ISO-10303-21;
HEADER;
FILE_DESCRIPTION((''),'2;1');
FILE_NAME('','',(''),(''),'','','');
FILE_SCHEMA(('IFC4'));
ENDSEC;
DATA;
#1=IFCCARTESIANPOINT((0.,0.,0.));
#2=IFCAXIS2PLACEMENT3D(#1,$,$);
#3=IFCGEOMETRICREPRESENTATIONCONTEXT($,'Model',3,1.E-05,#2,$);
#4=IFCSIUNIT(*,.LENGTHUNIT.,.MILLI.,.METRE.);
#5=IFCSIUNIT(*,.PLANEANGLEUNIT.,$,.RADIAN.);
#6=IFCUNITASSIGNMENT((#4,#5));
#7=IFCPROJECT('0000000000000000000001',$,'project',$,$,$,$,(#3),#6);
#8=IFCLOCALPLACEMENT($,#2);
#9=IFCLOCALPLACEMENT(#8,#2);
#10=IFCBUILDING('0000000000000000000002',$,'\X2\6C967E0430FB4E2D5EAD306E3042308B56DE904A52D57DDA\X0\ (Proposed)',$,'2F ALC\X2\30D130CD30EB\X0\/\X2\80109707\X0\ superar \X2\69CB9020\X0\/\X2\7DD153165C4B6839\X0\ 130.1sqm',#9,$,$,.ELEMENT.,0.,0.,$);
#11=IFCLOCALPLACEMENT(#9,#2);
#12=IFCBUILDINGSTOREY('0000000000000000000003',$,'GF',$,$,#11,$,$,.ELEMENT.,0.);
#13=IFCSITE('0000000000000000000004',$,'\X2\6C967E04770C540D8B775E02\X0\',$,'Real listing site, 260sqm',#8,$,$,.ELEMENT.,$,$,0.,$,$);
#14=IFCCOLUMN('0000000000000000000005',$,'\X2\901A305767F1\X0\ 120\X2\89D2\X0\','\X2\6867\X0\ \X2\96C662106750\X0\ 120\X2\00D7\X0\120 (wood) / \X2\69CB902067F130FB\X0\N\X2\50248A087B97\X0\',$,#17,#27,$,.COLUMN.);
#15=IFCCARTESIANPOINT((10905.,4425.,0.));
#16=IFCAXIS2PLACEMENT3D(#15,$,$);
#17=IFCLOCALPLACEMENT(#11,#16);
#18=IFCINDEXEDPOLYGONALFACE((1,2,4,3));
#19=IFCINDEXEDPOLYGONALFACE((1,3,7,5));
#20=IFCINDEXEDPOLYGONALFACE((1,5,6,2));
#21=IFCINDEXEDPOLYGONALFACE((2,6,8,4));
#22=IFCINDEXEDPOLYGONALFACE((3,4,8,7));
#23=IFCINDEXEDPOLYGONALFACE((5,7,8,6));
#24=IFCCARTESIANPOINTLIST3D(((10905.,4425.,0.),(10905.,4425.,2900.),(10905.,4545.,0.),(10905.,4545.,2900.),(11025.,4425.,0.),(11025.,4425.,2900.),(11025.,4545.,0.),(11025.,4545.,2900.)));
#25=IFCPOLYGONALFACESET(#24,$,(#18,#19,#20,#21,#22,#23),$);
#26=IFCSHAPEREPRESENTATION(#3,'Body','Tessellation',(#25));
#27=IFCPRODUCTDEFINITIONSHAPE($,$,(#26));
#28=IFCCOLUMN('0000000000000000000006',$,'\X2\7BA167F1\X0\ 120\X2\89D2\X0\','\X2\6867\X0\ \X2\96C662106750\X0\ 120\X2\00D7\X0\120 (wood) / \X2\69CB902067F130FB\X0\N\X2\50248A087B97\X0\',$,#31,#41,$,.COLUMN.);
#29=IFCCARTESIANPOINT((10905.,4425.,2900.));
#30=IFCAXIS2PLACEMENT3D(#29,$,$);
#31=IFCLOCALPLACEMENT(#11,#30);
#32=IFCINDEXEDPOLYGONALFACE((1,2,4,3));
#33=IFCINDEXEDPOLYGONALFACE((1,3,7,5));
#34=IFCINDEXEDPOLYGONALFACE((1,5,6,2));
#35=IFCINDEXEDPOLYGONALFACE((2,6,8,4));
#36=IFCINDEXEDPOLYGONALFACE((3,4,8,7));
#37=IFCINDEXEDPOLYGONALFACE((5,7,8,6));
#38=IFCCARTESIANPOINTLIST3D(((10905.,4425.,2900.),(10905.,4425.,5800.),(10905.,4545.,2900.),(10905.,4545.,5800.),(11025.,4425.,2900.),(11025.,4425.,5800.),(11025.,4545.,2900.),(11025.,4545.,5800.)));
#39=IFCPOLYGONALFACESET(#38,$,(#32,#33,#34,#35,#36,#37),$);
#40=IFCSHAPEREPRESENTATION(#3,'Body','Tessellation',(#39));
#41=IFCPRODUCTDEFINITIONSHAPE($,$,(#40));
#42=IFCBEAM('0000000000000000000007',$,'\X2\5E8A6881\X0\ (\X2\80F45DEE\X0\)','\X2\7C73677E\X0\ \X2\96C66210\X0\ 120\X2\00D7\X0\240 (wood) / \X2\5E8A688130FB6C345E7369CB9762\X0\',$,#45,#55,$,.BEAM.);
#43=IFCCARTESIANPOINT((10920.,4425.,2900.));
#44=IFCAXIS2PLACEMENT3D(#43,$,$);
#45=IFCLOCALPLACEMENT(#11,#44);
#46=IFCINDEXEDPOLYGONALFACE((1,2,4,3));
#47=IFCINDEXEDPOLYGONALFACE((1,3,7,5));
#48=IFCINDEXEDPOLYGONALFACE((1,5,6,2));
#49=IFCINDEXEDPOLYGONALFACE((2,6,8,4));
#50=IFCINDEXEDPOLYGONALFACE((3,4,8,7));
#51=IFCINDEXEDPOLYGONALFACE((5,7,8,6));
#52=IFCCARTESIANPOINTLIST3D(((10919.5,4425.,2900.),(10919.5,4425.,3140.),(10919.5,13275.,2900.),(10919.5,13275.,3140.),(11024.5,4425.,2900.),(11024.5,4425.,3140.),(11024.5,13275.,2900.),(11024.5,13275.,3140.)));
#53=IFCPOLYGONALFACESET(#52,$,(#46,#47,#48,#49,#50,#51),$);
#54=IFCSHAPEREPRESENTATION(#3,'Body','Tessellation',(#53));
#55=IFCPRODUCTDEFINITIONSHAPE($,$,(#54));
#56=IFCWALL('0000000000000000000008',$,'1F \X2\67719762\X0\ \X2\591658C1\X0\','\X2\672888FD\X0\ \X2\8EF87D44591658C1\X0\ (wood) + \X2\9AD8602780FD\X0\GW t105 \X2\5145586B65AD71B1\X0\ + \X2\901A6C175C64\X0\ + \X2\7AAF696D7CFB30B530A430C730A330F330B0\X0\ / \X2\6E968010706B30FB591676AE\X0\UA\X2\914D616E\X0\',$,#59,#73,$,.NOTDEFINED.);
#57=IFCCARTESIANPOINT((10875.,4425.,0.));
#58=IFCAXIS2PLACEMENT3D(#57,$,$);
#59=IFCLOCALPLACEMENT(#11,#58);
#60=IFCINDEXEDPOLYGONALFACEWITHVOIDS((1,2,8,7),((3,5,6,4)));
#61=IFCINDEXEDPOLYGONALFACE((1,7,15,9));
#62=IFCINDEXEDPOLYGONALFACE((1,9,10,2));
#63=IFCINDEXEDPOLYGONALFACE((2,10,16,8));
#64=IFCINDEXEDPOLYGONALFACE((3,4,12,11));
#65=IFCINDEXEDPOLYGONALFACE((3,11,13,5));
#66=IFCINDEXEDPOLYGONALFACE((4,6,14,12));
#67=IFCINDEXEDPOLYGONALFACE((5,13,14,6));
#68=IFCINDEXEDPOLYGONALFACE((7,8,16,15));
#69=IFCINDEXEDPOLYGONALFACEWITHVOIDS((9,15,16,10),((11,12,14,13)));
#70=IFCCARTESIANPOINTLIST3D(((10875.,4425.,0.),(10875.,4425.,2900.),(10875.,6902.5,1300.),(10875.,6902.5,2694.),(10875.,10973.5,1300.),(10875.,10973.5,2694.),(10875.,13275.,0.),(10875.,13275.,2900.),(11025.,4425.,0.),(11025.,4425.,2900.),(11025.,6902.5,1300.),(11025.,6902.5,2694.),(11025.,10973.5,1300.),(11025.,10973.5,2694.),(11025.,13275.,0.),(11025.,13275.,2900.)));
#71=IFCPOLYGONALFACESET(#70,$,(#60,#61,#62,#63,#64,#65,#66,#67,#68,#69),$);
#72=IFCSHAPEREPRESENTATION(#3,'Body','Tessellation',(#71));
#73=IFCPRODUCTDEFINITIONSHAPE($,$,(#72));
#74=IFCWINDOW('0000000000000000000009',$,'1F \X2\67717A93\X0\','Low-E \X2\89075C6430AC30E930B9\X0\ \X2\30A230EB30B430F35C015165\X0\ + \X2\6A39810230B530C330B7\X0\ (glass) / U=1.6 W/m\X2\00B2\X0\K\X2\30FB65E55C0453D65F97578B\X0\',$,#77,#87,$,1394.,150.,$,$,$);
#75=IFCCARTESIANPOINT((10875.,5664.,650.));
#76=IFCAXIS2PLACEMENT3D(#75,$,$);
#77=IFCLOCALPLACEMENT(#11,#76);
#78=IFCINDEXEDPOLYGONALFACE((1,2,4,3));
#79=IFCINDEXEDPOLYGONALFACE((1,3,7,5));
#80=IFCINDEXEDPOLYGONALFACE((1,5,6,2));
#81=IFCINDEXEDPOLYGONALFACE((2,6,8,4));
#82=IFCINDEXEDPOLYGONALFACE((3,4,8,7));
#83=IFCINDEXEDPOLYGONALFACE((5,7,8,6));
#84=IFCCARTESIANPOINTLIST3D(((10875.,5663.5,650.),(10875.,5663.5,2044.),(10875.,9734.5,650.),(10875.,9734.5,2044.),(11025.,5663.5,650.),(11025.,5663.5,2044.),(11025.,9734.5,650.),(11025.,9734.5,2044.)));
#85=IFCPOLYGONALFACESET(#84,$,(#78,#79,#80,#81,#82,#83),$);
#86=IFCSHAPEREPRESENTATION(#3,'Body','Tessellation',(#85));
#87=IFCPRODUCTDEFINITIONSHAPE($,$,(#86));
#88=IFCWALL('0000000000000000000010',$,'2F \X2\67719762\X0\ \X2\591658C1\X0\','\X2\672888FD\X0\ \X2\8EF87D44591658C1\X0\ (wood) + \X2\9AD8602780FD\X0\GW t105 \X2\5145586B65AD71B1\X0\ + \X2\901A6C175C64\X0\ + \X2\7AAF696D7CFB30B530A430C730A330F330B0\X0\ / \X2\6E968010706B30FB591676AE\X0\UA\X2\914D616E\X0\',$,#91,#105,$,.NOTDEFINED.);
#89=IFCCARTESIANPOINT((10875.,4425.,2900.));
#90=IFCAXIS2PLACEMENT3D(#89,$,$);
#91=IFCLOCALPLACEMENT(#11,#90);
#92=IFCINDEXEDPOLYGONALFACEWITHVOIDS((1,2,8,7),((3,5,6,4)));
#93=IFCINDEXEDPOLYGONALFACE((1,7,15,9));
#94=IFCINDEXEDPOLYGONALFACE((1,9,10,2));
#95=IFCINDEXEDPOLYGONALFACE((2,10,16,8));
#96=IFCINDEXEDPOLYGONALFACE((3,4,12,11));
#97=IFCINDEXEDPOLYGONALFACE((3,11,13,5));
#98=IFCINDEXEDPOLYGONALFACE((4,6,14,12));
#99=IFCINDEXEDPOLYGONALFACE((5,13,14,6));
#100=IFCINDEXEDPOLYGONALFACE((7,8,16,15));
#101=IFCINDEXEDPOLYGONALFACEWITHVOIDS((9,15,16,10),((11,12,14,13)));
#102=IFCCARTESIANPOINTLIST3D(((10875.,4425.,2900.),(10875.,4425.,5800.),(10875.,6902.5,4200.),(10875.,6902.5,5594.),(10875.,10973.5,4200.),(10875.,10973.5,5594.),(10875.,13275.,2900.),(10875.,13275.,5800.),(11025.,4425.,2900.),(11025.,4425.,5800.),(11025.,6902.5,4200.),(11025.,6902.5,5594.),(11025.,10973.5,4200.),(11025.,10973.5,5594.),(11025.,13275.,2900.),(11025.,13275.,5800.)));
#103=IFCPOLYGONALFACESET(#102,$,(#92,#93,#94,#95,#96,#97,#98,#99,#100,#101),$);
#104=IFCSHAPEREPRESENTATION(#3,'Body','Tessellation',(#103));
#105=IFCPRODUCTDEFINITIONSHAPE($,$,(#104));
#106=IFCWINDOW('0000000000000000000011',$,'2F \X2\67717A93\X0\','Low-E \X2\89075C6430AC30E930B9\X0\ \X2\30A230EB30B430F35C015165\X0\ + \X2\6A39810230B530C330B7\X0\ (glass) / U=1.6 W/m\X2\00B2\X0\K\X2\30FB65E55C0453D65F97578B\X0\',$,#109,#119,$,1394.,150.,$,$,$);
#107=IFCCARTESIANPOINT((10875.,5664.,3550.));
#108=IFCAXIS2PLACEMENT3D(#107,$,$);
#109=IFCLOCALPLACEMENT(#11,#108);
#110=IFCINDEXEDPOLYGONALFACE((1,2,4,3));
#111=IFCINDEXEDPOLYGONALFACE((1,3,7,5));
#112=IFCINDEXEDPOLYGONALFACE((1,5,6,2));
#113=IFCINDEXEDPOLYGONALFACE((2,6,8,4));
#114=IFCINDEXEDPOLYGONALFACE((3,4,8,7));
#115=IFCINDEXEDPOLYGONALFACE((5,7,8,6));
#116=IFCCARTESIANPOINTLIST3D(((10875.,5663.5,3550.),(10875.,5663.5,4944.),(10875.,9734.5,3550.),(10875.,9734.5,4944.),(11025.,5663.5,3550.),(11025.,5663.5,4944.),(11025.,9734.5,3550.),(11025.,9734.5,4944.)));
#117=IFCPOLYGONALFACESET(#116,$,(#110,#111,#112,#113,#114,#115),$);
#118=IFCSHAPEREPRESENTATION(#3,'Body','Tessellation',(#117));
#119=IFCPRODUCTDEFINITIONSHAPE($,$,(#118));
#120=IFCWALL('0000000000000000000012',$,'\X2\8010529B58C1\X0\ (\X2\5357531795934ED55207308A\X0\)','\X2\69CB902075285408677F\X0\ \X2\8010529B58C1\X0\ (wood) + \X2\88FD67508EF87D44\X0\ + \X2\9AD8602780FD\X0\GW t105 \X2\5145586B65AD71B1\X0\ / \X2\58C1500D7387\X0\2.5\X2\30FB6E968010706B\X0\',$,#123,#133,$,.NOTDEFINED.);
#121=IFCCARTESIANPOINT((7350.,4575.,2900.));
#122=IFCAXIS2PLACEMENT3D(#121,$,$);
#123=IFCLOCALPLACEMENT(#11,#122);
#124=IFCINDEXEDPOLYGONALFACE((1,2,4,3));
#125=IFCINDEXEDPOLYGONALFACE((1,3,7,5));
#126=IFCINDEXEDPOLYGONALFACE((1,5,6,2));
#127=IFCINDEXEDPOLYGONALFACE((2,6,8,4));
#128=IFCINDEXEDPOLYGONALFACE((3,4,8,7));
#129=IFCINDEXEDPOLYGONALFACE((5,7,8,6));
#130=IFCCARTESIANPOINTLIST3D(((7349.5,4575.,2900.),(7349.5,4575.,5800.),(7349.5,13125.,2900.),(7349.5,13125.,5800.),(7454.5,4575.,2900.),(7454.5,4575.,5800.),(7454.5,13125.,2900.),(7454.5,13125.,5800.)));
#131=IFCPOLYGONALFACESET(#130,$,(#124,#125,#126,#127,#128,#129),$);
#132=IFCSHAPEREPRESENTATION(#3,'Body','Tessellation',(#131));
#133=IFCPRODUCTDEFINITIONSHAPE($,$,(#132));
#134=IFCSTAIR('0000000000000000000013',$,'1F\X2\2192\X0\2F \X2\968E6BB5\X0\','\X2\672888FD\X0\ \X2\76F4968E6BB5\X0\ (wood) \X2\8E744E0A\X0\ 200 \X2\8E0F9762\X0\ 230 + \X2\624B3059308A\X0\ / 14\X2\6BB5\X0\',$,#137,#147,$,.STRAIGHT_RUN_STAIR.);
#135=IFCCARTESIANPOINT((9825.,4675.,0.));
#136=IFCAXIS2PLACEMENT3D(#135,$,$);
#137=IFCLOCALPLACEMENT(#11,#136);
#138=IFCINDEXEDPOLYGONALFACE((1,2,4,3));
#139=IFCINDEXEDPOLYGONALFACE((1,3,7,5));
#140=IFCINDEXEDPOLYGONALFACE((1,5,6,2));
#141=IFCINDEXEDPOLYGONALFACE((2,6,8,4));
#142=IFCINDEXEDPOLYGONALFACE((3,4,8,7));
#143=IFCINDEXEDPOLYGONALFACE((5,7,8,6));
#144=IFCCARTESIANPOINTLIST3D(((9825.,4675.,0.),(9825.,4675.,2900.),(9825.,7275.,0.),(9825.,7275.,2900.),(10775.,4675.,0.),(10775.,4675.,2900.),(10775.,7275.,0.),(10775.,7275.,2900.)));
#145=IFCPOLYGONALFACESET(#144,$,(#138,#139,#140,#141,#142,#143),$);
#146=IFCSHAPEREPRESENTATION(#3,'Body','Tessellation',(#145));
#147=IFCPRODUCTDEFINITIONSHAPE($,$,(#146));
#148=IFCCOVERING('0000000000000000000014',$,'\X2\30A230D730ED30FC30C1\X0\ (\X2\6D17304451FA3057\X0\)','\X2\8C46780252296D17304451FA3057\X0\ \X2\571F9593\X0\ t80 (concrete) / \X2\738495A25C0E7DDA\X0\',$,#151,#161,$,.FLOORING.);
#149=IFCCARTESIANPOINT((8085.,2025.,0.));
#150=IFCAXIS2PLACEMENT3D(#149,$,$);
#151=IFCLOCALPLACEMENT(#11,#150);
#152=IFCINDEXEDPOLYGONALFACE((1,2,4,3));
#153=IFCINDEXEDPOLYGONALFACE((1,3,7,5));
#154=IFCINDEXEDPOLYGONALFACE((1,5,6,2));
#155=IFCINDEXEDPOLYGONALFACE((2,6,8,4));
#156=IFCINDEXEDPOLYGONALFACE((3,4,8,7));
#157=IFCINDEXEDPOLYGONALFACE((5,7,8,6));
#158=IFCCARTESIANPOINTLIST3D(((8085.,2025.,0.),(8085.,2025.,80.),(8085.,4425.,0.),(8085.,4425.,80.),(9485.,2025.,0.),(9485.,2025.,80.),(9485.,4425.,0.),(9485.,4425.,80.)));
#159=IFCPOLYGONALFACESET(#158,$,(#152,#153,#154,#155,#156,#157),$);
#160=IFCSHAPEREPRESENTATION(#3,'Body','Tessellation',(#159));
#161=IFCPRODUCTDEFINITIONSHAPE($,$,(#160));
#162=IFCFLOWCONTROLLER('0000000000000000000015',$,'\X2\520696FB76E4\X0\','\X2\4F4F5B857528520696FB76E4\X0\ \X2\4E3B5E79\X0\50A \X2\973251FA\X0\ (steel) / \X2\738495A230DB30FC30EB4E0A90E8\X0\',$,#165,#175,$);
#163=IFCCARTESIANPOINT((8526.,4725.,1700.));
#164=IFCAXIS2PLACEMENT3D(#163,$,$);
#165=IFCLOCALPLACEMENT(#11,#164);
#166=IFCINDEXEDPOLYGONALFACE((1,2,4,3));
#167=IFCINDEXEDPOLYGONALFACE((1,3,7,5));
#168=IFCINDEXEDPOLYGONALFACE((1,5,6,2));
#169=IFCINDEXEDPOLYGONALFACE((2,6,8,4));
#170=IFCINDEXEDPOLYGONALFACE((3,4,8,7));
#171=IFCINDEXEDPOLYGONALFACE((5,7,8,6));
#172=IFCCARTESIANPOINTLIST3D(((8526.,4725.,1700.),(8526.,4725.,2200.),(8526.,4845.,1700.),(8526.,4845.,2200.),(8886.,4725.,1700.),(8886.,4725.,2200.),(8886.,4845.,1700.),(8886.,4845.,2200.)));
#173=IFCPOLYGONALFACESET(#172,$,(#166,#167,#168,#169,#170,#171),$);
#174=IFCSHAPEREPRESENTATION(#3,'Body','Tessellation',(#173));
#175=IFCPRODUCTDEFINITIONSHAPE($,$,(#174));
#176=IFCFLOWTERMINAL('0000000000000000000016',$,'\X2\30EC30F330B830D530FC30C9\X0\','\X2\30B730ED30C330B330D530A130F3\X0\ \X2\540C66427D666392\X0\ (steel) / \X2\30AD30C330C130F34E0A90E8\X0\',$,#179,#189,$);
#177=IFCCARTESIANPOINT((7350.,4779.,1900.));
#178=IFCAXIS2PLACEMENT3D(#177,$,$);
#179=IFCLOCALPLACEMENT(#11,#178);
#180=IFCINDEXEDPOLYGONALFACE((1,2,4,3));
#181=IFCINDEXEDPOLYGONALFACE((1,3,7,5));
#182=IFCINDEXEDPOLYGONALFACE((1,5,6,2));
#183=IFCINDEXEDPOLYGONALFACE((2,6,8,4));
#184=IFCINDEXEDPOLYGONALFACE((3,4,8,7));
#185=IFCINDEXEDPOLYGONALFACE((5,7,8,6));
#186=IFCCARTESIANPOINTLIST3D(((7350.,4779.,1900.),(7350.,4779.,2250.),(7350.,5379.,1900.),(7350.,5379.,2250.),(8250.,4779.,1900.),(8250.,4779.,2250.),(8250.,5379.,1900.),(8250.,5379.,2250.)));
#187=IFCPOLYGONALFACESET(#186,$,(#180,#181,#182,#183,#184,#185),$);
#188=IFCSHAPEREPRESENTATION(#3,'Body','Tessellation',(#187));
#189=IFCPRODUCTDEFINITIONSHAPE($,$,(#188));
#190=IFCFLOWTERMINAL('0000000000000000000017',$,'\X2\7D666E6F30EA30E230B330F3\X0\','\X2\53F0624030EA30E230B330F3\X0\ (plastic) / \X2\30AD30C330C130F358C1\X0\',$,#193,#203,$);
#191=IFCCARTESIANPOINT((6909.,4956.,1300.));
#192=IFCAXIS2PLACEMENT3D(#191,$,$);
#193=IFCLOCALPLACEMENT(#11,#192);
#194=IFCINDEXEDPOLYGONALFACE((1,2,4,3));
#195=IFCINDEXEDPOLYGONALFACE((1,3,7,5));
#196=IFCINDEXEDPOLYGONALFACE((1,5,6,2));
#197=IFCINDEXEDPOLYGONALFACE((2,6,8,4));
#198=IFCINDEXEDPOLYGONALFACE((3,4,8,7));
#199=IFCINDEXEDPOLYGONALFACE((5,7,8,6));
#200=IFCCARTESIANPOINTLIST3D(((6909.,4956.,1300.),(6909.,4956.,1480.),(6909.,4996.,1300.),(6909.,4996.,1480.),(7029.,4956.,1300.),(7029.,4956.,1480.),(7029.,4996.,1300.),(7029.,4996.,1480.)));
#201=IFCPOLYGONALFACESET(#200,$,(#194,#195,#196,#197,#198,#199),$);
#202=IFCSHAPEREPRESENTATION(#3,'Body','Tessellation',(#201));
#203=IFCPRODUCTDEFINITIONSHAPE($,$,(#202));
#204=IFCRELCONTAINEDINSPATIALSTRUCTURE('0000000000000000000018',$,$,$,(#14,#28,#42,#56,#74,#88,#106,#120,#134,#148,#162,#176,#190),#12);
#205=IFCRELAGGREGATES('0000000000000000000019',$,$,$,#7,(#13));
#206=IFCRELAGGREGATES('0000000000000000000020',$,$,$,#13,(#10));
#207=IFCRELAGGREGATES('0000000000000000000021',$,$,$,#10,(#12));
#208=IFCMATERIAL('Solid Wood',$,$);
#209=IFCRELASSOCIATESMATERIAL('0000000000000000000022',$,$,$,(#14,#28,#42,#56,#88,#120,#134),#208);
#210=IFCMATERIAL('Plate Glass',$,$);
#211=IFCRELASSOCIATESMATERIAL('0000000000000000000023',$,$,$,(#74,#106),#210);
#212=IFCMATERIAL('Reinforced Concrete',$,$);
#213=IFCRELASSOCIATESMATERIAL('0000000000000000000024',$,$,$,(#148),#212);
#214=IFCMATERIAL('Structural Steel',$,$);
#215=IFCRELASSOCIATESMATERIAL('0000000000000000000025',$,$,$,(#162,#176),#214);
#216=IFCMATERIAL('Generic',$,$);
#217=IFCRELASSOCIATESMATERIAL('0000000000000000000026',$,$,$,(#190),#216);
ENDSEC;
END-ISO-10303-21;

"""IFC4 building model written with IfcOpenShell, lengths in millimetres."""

from ifc_helpers import new_model, si_unit, frame, frame_2d, origin, place, context, project, spatial, rectangle, extrude, material, element, fill, save


model = new_model("IFC4")

# Units and contexts
model_context = context("Model", 3, precision=1e-05, world=origin())
ifc_project = project(units=[si_unit("LENGTHUNIT", "METRE", prefix="MILLI"), si_unit("PLANEANGLEUNIT", "RADIAN")], contexts=[model_context])

# Site, building, storey
site_placement = place(None, origin())
site = spatial("IfcSite", under=ifc_project, at=site_placement, Name="沖縄県名護市", ObjectType="Real listing site, 260sqm", CompositionType="ELEMENT", RefElevation=0.0)
building_placement = place(site_placement, origin())
building = spatial("IfcBuilding", under=site, at=building_placement, Name="沖縄・中庭のある回遊動線 (Proposed)", ObjectType="2F ALCパネル/耐震 superar 構造/緑化屋根 130.1sqm", CompositionType="ELEMENT", ElevationOfRefHeight=0.0, ElevationOfTerrain=0.0)
storey_placement = place(building_placement, origin())
storey = spatial("IfcBuildingStorey", under=building, at=storey_placement, Name="GF", CompositionType="ELEMENT", Elevation=0.0)

# Columns
ifc_material_1 = material(Name="Solid Wood")
column_1_placement = place(storey_placement, frame((10905.0, 4425.0, 0.0)))
element("IfcColumn", 1, at=column_1_placement, inside=storey, material=ifc_material_1, Name="通し柱 120角", Description="桧 集成材 120×120 (wood) / 構造柱・N値計算", PredefinedType="COLUMN", context=model_context, shape_type="SweptSolid", body=[
    extrude(rectangle(XDim=120.0, YDim=120.0, at=frame_2d((60.0, 60.0))), frame((10905.0, 4425.0, 0.0)), (0.0, 0.0, 1.0), 2900.0),
])
column_2_placement = place(storey_placement, frame((10905.0, 4425.0, 2900.0)))
element("IfcColumn", 2, at=column_2_placement, inside=storey, material=ifc_material_1, Name="管柱 120角", Description="桧 集成材 120×120 (wood) / 構造柱・N値計算", PredefinedType="COLUMN", context=model_context, shape_type="SweptSolid", body=[
    extrude(rectangle(XDim=120.0, YDim=120.0, at=frame_2d((60.0, 60.0))), frame((10905.0, 4425.0, 2900.0)), (0.0, 0.0, 1.0), 2900.0),
])

# Beam
beam_1_placement = place(storey_placement, frame((10920.0, 4425.0, 2900.0)))
element("IfcBeam", 3, at=beam_1_placement, inside=storey, material=ifc_material_1, Name="床梁 (胴差)", Description="米松 集成 120×240 (wood) / 床梁・水平構面", PredefinedType="BEAM", context=model_context, shape_type="SweptSolid", body=[
    extrude(rectangle(XDim=105.0, YDim=8850.0, at=frame_2d((52.0, 4425.0))), frame((10920.0, 4425.0, 2900.0)), (0.0, 0.0, 1.0), 240.0),
])

# Wall, opening, window
wall_1_placement = place(storey_placement, frame((10875.0, 4425.0, 0.0)))
wall_1 = element("IfcWall", 4, at=wall_1_placement, inside=storey, material=ifc_material_1, Name="1F 東面 外壁", Description="木製 軸組外壁 (wood) + 高性能GW t105 充填断熱 + 通気層 + 窯業系サイディング / 準耐火・外皮UA配慮", PredefinedType="NOTDEFINED", context=model_context, shape_type="SweptSolid", body=[
    extrude(rectangle(XDim=150.0, YDim=8850.0, at=frame_2d((75.0, 4425.0))), frame((10875.0, 4425.0, 0.0)), (0.0, 0.0, 1.0), 2900.0),
])
opening_1_placement = place(storey_placement, frame((10875.0, 5664.0, 650.0)))
opening_1 = element("IfcOpeningElement", 5, at=opening_1_placement, cuts=wall_1, PredefinedType="NOTDEFINED", context=model_context, shape_type="SweptSolid", body=[
    extrude(rectangle(XDim=150.0, YDim=4071.0, at=frame_2d((75.0, 2035.0))), frame((10875.0, 5664.0, 650.0)), (0.0, 0.0, 1.0), 1394.0),
])
ifc_material_2 = material(Name="Plate Glass")
window_1_placement = place(storey_placement, frame((10875.0, 5664.0, 650.0)))
window_1 = element("IfcWindow", 6, at=window_1_placement, inside=storey, material=ifc_material_2, Name="1F 東窓", Description="Low-E 複層ガラス アルゴン封入 + 樹脂サッシ (glass) / U=1.6 W/m²K・日射取得型", OverallHeight=1394.0, OverallWidth=150.0, context=model_context, shape_type="SweptSolid", body=[
    extrude(rectangle(XDim=150.0, YDim=4071.0, at=frame_2d((75.0, 2035.0))), frame((10875.0, 5664.0, 650.0)), (0.0, 0.0, 1.0), 1394.0),
])
fill(opening_1, window_1)

# Wall, opening, window
wall_2_placement = place(storey_placement, frame((10875.0, 4425.0, 2900.0)))
wall_2 = element("IfcWall", 7, at=wall_2_placement, inside=storey, material=ifc_material_1, Name="2F 東面 外壁", Description="木製 軸組外壁 (wood) + 高性能GW t105 充填断熱 + 通気層 + 窯業系サイディング / 準耐火・外皮UA配慮", PredefinedType="NOTDEFINED", context=model_context, shape_type="SweptSolid", body=[
    extrude(rectangle(XDim=150.0, YDim=8850.0, at=frame_2d((75.0, 4425.0))), frame((10875.0, 4425.0, 2900.0)), (0.0, 0.0, 1.0), 2900.0),
])
opening_2_placement = place(storey_placement, frame((10875.0, 5664.0, 3550.0)))
opening_2 = element("IfcOpeningElement", 8, at=opening_2_placement, cuts=wall_2, PredefinedType="NOTDEFINED", context=model_context, shape_type="SweptSolid", body=[
    extrude(rectangle(XDim=150.0, YDim=4071.0, at=frame_2d((75.0, 2035.0))), frame((10875.0, 5664.0, 3550.0)), (0.0, 0.0, 1.0), 1394.0),
])
window_2_placement = place(storey_placement, frame((10875.0, 5664.0, 3550.0)))
window_2 = element("IfcWindow", 9, at=window_2_placement, inside=storey, material=ifc_material_2, Name="2F 東窓", Description="Low-E 複層ガラス アルゴン封入 + 樹脂サッシ (glass) / U=1.6 W/m²K・日射取得型", OverallHeight=1394.0, OverallWidth=150.0, context=model_context, shape_type="SweptSolid", body=[
    extrude(rectangle(XDim=150.0, YDim=4071.0, at=frame_2d((75.0, 2035.0))), frame((10875.0, 5664.0, 3550.0)), (0.0, 0.0, 1.0), 1394.0),
])
fill(opening_2, window_2)

# Wall
wall_3_placement = place(storey_placement, frame((7350.0, 4575.0, 2900.0)))
element("IfcWall", 10, at=wall_3_placement, inside=storey, material=ifc_material_1, Name="耐力壁 (南北間仕切り)", Description="構造用合板 耐力壁 (wood) + 製材軸組 + 高性能GW t105 充填断熱 / 壁倍率2.5・準耐火", PredefinedType="NOTDEFINED", context=model_context, shape_type="SweptSolid", body=[
    extrude(rectangle(XDim=105.0, YDim=8550.0, at=frame_2d((52.0, 4275.0))), frame((7350.0, 4575.0, 2900.0)), (0.0, 0.0, 1.0), 2900.0),
])

# Stair
stair_placement = place(storey_placement, frame((9825.0, 4675.0, 0.0)))
element("IfcStair", 11, at=stair_placement, inside=storey, material=ifc_material_1, Name="1F→2F 階段", Description="木製 直階段 (wood) 蹴上 200 踏面 230 + 手すり / 14段", PredefinedType="STRAIGHT_RUN_STAIR", context=model_context, shape_type="SweptSolid", body=[
    extrude(rectangle(XDim=950.0, YDim=2600.0, at=frame_2d((475.0, 1300.0))), frame((9825.0, 4675.0, 0.0)), (0.0, 0.0, 1.0), 2900.0),
])

# Covering
ifc_material_3 = material(Name="Reinforced Concrete")
covering_placement = place(storey_placement, frame((8085.0, 2025.0, 0.0)))
element("IfcCovering", 12, at=covering_placement, inside=storey, material=ifc_material_3, Name="アプローチ (洗い出し)", Description="豆砂利洗い出し 土間 t80 (concrete) / 玄関導線", PredefinedType="FLOORING", context=model_context, shape_type="SweptSolid", body=[
    extrude(rectangle(XDim=1400.0, YDim=2400.0, at=frame_2d((700.0, 1200.0))), frame((8085.0, 2025.0, 0.0)), (0.0, 0.0, 1.0), 80.0),
])

# Flow controller
ifc_material_4 = material(Name="Structural Steel")
flow_controller_placement = place(storey_placement, frame((8526.0, 4725.0, 1700.0)))
element("IfcFlowController", 13, at=flow_controller_placement, inside=storey, material=ifc_material_4, Name="分電盤", Description="住宅用分電盤 主幹50A 露出 (steel) / 玄関ホール上部", context=model_context, shape_type="SweptSolid", body=[
    extrude(rectangle(XDim=360.0, YDim=120.0, at=frame_2d((180.0, 60.0))), frame((8526.0, 4725.0, 1700.0)), (0.0, 0.0, 1.0), 500.0),
])

# Flow terminals
flow_terminal_1_placement = place(storey_placement, frame((7350.0, 4779.0, 1900.0)))
element("IfcFlowTerminal", 14, at=flow_terminal_1_placement, inside=storey, material=ifc_material_4, Name="レンジフード", Description="シロッコファン 同時給排 (steel) / キッチン上部", context=model_context, shape_type="SweptSolid", body=[
    extrude(rectangle(XDim=900.0, YDim=600.0, at=frame_2d((450.0, 300.0))), frame((7350.0, 4779.0, 1900.0)), (0.0, 0.0, 1.0), 350.0),
])
ifc_material_5 = material(Name="Generic")
flow_terminal_2_placement = place(storey_placement, frame((6909.0, 4956.0, 1300.0)))
element("IfcFlowTerminal", 15, at=flow_terminal_2_placement, inside=storey, material=ifc_material_5, Name="給湯リモコン", Description="台所リモコン (plastic) / キッチン壁", context=model_context, shape_type="SweptSolid", body=[
    extrude(rectangle(XDim=120.0, YDim=40.0, at=frame_2d((60.0, 20.0))), frame((6909.0, 4956.0, 1300.0)), (0.0, 0.0, 1.0), 180.0),
])

save(model, "model.ifc")
